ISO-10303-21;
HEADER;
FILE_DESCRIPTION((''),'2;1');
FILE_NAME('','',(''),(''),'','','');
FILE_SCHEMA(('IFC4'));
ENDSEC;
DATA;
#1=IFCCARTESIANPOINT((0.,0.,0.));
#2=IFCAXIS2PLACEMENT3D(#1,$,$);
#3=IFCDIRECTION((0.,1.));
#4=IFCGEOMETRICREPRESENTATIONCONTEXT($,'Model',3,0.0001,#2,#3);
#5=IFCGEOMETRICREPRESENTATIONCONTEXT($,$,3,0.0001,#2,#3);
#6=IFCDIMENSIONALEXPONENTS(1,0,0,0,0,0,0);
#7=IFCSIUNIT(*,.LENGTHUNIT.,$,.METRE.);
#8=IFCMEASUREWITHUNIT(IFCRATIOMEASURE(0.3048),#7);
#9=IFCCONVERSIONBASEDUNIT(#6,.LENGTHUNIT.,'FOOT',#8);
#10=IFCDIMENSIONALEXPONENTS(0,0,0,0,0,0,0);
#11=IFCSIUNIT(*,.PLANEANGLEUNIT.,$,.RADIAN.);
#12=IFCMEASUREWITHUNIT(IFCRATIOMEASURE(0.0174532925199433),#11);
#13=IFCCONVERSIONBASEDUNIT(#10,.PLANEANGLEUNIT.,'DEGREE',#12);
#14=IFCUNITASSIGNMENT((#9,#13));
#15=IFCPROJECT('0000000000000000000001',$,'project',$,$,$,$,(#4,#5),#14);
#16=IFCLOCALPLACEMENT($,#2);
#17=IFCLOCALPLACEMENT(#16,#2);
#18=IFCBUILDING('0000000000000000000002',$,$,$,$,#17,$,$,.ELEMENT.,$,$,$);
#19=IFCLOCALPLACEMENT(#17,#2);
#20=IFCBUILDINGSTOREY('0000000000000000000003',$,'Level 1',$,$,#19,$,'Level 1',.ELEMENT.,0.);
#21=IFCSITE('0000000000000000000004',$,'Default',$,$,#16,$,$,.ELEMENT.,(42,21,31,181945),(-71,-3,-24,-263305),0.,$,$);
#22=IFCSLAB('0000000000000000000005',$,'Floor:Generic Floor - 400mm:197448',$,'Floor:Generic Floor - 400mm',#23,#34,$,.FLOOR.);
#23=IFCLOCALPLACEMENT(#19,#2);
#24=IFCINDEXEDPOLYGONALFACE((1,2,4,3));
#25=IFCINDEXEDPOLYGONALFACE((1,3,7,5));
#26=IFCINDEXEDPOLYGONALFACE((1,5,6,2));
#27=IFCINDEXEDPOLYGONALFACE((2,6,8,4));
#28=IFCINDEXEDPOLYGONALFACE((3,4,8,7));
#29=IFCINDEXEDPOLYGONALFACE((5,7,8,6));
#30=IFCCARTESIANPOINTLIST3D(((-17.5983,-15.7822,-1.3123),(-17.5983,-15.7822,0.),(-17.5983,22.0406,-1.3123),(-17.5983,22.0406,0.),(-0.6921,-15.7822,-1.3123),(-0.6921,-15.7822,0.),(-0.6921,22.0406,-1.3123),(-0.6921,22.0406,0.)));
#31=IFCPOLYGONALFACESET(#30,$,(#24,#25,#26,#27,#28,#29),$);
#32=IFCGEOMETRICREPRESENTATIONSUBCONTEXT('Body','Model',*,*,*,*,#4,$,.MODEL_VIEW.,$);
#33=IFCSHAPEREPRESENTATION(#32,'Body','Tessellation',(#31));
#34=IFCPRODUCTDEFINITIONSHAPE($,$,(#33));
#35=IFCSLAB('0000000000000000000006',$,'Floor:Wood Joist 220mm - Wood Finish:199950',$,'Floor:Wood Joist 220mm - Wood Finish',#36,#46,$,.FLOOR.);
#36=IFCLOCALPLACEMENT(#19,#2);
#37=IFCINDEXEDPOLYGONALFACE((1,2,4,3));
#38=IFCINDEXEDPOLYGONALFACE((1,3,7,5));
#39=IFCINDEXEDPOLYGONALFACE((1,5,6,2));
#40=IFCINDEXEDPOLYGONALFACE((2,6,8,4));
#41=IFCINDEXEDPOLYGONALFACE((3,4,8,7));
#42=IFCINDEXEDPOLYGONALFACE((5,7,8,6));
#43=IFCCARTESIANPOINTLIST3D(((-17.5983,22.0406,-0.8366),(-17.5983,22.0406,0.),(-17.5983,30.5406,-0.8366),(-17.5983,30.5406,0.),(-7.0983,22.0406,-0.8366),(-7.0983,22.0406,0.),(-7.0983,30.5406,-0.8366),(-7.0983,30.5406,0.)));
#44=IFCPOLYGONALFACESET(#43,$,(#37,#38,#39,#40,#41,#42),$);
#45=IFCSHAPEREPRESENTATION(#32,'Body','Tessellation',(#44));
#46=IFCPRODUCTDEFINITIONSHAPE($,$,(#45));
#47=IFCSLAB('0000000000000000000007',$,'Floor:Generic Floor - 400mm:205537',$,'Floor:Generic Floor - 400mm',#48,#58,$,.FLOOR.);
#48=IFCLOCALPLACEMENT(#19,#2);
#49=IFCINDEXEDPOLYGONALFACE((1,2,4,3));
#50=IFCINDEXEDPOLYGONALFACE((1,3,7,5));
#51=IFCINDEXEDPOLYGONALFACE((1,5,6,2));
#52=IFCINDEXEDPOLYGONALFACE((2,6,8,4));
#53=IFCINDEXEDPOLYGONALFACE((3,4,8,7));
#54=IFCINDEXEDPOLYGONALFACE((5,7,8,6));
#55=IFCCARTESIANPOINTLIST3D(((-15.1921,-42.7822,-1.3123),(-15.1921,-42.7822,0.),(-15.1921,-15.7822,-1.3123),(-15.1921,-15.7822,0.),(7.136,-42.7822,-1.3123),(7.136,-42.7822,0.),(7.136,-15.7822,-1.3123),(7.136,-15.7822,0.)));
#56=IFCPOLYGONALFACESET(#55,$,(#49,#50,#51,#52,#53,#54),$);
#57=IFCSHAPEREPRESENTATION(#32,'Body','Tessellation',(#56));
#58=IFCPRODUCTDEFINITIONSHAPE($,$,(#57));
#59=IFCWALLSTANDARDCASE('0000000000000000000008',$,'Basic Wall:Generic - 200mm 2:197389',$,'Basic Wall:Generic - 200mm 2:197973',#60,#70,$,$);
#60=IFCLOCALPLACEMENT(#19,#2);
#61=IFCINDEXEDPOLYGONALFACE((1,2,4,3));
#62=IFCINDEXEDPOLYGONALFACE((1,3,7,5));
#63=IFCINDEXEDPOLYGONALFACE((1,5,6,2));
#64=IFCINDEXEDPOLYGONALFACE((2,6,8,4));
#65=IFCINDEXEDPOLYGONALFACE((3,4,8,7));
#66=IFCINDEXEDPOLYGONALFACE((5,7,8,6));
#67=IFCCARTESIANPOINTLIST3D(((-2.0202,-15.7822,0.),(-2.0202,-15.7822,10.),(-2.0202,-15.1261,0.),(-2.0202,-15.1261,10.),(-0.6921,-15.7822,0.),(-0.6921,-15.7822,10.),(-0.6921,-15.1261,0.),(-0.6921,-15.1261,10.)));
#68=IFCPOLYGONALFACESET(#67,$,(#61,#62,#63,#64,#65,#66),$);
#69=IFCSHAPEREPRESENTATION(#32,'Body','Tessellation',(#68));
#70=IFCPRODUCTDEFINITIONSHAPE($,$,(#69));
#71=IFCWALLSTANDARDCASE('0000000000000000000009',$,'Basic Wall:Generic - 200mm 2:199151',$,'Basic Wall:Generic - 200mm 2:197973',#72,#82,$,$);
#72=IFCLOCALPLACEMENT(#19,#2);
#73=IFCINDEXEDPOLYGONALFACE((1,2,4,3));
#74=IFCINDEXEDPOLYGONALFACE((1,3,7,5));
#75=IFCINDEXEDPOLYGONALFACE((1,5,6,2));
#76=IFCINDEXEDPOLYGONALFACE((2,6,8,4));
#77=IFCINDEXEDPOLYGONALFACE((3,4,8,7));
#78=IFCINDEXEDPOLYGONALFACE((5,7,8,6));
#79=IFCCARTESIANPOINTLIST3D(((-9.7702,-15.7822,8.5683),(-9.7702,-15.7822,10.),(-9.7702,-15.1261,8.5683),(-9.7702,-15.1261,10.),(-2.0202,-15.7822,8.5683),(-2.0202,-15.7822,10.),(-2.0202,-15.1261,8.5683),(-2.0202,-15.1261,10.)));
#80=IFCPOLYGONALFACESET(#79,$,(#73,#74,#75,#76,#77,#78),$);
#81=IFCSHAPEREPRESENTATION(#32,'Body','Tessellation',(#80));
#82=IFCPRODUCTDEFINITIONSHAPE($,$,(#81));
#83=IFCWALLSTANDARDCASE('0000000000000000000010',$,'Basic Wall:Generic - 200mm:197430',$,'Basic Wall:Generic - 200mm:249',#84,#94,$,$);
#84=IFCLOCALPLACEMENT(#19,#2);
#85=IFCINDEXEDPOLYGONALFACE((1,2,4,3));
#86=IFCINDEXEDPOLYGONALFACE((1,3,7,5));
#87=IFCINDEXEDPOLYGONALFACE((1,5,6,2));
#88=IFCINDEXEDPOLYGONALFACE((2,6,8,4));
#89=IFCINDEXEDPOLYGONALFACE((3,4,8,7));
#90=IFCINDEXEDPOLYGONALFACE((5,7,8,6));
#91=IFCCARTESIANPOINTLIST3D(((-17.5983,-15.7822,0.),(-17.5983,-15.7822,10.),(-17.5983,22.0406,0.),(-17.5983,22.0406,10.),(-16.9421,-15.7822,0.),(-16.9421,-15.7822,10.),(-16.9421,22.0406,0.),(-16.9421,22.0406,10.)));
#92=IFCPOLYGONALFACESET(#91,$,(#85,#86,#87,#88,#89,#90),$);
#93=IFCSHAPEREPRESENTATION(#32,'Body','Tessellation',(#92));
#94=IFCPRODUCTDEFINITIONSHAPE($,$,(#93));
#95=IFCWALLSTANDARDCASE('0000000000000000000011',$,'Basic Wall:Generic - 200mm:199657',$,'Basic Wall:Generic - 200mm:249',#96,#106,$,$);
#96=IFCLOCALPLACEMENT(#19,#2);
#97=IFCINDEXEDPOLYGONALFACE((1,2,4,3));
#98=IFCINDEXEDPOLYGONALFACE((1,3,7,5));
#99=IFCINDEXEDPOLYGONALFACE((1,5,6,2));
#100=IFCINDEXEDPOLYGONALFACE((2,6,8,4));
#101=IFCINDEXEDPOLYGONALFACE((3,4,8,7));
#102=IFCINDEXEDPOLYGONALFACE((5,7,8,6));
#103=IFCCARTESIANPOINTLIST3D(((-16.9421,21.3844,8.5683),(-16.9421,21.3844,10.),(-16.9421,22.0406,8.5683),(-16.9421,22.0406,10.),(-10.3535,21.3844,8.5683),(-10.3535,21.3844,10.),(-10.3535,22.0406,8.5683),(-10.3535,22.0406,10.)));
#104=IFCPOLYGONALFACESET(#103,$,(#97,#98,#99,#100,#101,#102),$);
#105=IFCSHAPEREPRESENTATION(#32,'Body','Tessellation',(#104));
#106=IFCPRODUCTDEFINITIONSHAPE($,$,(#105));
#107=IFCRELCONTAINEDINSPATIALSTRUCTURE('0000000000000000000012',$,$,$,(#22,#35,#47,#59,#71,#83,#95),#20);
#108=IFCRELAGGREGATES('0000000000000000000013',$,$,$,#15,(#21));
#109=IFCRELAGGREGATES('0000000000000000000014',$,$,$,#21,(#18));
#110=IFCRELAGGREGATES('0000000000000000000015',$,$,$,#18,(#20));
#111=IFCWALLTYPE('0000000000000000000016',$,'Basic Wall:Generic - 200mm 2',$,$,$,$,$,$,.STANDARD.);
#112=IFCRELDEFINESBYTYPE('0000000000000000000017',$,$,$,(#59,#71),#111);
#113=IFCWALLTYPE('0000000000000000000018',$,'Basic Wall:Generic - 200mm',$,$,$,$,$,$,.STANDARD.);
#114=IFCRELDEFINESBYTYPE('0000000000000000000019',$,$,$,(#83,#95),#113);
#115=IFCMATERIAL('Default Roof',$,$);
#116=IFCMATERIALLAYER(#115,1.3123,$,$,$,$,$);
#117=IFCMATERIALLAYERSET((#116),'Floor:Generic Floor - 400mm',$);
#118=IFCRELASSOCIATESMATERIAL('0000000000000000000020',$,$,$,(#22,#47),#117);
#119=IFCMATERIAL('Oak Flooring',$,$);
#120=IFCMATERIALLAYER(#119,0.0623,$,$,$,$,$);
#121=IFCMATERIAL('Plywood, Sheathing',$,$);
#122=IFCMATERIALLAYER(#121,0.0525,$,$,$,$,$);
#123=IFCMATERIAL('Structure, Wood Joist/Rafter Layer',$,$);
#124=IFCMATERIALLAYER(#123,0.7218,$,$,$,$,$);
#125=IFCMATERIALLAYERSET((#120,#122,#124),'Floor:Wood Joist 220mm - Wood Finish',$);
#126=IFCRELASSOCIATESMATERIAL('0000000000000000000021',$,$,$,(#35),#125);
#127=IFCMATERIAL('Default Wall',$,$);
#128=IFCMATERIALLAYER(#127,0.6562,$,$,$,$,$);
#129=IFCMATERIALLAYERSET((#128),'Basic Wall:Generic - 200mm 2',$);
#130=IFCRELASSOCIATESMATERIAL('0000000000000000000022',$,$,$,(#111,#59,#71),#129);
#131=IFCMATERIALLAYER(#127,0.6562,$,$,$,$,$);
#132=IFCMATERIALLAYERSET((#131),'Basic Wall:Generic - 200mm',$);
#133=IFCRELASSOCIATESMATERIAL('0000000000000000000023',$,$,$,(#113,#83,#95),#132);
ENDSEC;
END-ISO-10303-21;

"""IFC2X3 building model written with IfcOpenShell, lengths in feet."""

from ifc_helpers import new_model, entity, si_unit, converted_unit, direction, frame, frame_2d, origin, origin_2d_with_axis, place, context, subcontext, project, spatial, rectangle, extrude, clip, halfspace, material, layer, layer_set, layer_usage, type_object, element, save


model = new_model("IFC2X3")

# Units and contexts
model_context = context("Model", 3, precision=0.0001, world=origin(), true_north=direction((0.0, 1.0)))
context_of_model = context(None, 3, precision=0.0001, world=origin(), true_north=direction((0.0, 1.0)))
body_context = subcontext(model_context, "Body", "Model", "MODEL_VIEW")
ifc_project = project(units=[converted_unit("LENGTHUNIT", "FOOT", entity("IfcRatioMeasure", 0.3048), si_unit("LENGTHUNIT", "METRE"), dimensions=[1, 0, 0, 0, 0, 0, 0]), converted_unit("PLANEANGLEUNIT", "DEGREE", entity("IfcRatioMeasure", 0.0174532925199433), si_unit("PLANEANGLEUNIT", "RADIAN"), dimensions=[0, 0, 0, 0, 0, 0, 0])], contexts=[model_context, context_of_model])

# Site, building, storey
site_placement = place(None, origin())
site = spatial("IfcSite", under=ifc_project, at=site_placement, Name="Default", CompositionType="ELEMENT", RefLatitude=(42, 21, 31, 181945), RefLongitude=(-71, -3, -24, -263305), RefElevation=0.0)
building_placement = place(site_placement, origin())
building = spatial("IfcBuilding", under=site, at=building_placement, CompositionType="ELEMENT")
storey_placement = place(building_placement, origin())
storey = spatial("IfcBuildingStorey", under=building, at=storey_placement, Name="Level 1", LongName="Level 1", CompositionType="ELEMENT", Elevation=0.0)

# Slabs
ifc_material_1 = material(Name="Default Roof")
ifc_layer_1 = layer(ifc_material_1, 1.3123)
ifc_layer_set_1 = layer_set([ifc_layer_1], Name="Floor:Generic Floor - 400mm")
ifc_layer_usage_1 = layer_usage(ifc_layer_set_1, "AXIS3", "POSITIVE", 0.0)
slab_1_placement = place(storey_placement, origin())
element("IfcSlab", 1, at=slab_1_placement, inside=storey, material=ifc_layer_usage_1, Name="Floor:Generic Floor - 400mm:197448", ObjectType="Floor:Generic Floor - 400mm", PredefinedType="FLOOR", context=body_context, shape_type="SweptSolid", body=[
    extrude(rectangle(XDim=37.8228, YDim=16.9062, at=frame_2d((0.0, 0.0), x_axis=(1.0, 0.0))), frame((-9.1452, 3.1292, 0.0), z_axis=(0.0, 0.0, -1.0), x_axis=(0.0, 1.0, 0.0)), (0.0, 0.0, 1.0), 1.3123),
])
ifc_material_2 = material(Name="Oak Flooring")
ifc_layer_2 = layer(ifc_material_2, 0.0623)
ifc_material_3 = material(Name="Plywood, Sheathing")
ifc_layer_3 = layer(ifc_material_3, 0.0525)
ifc_material_4 = material(Name="Structure, Wood Joist/Rafter Layer")
ifc_layer_4 = layer(ifc_material_4, 0.7218)
ifc_layer_set_2 = layer_set([ifc_layer_2, ifc_layer_3, ifc_layer_4], Name="Floor:Wood Joist 220mm - Wood Finish")
ifc_layer_usage_2 = layer_usage(ifc_layer_set_2, "AXIS3", "POSITIVE", 0.0)
slab_2_placement = place(storey_placement, origin())
element("IfcSlab", 2, at=slab_2_placement, inside=storey, material=ifc_layer_usage_2, Name="Floor:Wood Joist 220mm - Wood Finish:199950", ObjectType="Floor:Wood Joist 220mm - Wood Finish", PredefinedType="FLOOR", context=body_context, shape_type="SweptSolid", body=[
    extrude(rectangle(XDim=8.5, YDim=10.5, at=origin_2d_with_axis()), frame((-12.3483, 26.2906, 0.0), z_axis=(0.0, 0.0, -1.0), x_axis=(0.0, 1.0, 0.0)), (0.0, 0.0, 1.0), 0.8366),
])
ifc_layer_usage_3 = layer_usage(ifc_layer_set_1, "AXIS3", "POSITIVE", 0.0)
slab_3_placement = place(storey_placement, origin())
element("IfcSlab", 3, at=slab_3_placement, inside=storey, material=ifc_layer_usage_3, Name="Floor:Generic Floor - 400mm:205537", ObjectType="Floor:Generic Floor - 400mm", PredefinedType="FLOOR", context=body_context, shape_type="SweptSolid", body=[
    extrude(rectangle(XDim=27.0, YDim=22.3281, at=frame_2d((0.0, 0.0), x_axis=(1.0, 0.0))), frame((-4.0281, -29.2822, 0.0), z_axis=(0.0, 0.0, -1.0), x_axis=(0.0, 1.0, 0.0)), (0.0, 0.0, 1.0), 1.3123),
])

# Wall
ifc_material_5 = material(Name="Default Wall")
ifc_layer_5 = layer(ifc_material_5, 0.6562)
ifc_layer_set_3 = layer_set([ifc_layer_5], Name="Basic Wall:Generic - 200mm 2")
ifc_layer_usage_4 = layer_usage(ifc_layer_set_3, "AXIS2", "NEGATIVE", 0.3281)
wall_type_1 = type_object("IfcWallType", Name="Basic Wall:Generic - 200mm 2", PredefinedType="STANDARD", material=ifc_layer_set_3)
wall_1_placement = place(storey_placement, frame((-0.6921, -15.4541, 0.0), z_axis=(0.0, 0.0, 1.0), x_axis=(-1.0, 0.0, 0.0)))
element("IfcWallStandardCase", 4, at=wall_1_placement, inside=storey, type_object=wall_type_1, material=ifc_layer_usage_4, Name="Basic Wall:Generic - 200mm 2:197389", ObjectType="Basic Wall:Generic - 200mm 2:197973", context=body_context, shape_type="Clipping", body=[
    clip(extrude(rectangle(XDim=1.3281, YDim=0.6562, at=frame_2d((0.664, 0.0), x_axis=(-1.0, 0.0))), origin(), (0.0, 0.0, 1.0), 10.0), halfspace(origin(), True)),
])

# Walls
ifc_layer_usage_5 = layer_usage(ifc_layer_set_3, "AXIS2", "NEGATIVE", 0.3281)
wall_2_placement = place(storey_placement, frame((-2.0202, -15.4541, 8.5683), z_axis=(0.0, 0.0, 1.0), x_axis=(-1.0, 0.0, 0.0)))
element("IfcWallStandardCase", 5, at=wall_2_placement, inside=storey, type_object=wall_type_1, material=ifc_layer_usage_5, Name="Basic Wall:Generic - 200mm 2:199151", ObjectType="Basic Wall:Generic - 200mm 2:197973", context=body_context, shape_type="Clipping", body=[
    clip(extrude(rectangle(XDim=7.75, YDim=0.6562, at=frame_2d((3.875, 0.0), x_axis=(-1.0, 0.0))), origin(), (0.0, 0.0, 1.0), 1.4317), halfspace(origin(), True)),
])
ifc_layer_6 = layer(ifc_material_5, 0.6562)
ifc_layer_set_4 = layer_set([ifc_layer_6], Name="Basic Wall:Generic - 200mm")
ifc_layer_usage_6 = layer_usage(ifc_layer_set_4, "AXIS2", "NEGATIVE", 0.3281)
wall_type_2 = type_object("IfcWallType", Name="Basic Wall:Generic - 200mm", PredefinedType="STANDARD", material=ifc_layer_set_4)
wall_3_placement = place(storey_placement, frame((-17.2702, -15.7822, 0.0), z_axis=(0.0, 0.0, 1.0), x_axis=(0.0, 1.0, 0.0)))
element("IfcWallStandardCase", 6, at=wall_3_placement, inside=storey, type_object=wall_type_2, material=ifc_layer_usage_6, Name="Basic Wall:Generic - 200mm:197430", ObjectType="Basic Wall:Generic - 200mm:249", context=body_context, shape_type="Clipping", body=[
    clip(extrude(rectangle(XDim=37.8228, YDim=0.6562, at=frame_2d((18.9114, 0.0), x_axis=(-1.0, 0.0))), origin(), (0.0, 0.0, 1.0), 10.0), halfspace(origin(), True)),
])

# Wall
ifc_layer_usage_7 = layer_usage(ifc_layer_set_4, "AXIS2", "NEGATIVE", 0.3281)
wall_4_placement = place(storey_placement, frame((-16.9421, 21.7125, 8.5683)))
element("IfcWallStandardCase", 7, at=wall_4_placement, inside=storey, type_object=wall_type_2, material=ifc_layer_usage_7, Name="Basic Wall:Generic - 200mm:199657", ObjectType="Basic Wall:Generic - 200mm:249", context=body_context, shape_type="Clipping", body=[
    clip(extrude(rectangle(XDim=6.5886, YDim=0.6562, at=frame_2d((3.2943, 0.0), x_axis=(-1.0, 0.0))), origin(), (0.0, 0.0, 1.0), 1.4317), halfspace(origin(), True)),
])

save(model, "model.ifc")
